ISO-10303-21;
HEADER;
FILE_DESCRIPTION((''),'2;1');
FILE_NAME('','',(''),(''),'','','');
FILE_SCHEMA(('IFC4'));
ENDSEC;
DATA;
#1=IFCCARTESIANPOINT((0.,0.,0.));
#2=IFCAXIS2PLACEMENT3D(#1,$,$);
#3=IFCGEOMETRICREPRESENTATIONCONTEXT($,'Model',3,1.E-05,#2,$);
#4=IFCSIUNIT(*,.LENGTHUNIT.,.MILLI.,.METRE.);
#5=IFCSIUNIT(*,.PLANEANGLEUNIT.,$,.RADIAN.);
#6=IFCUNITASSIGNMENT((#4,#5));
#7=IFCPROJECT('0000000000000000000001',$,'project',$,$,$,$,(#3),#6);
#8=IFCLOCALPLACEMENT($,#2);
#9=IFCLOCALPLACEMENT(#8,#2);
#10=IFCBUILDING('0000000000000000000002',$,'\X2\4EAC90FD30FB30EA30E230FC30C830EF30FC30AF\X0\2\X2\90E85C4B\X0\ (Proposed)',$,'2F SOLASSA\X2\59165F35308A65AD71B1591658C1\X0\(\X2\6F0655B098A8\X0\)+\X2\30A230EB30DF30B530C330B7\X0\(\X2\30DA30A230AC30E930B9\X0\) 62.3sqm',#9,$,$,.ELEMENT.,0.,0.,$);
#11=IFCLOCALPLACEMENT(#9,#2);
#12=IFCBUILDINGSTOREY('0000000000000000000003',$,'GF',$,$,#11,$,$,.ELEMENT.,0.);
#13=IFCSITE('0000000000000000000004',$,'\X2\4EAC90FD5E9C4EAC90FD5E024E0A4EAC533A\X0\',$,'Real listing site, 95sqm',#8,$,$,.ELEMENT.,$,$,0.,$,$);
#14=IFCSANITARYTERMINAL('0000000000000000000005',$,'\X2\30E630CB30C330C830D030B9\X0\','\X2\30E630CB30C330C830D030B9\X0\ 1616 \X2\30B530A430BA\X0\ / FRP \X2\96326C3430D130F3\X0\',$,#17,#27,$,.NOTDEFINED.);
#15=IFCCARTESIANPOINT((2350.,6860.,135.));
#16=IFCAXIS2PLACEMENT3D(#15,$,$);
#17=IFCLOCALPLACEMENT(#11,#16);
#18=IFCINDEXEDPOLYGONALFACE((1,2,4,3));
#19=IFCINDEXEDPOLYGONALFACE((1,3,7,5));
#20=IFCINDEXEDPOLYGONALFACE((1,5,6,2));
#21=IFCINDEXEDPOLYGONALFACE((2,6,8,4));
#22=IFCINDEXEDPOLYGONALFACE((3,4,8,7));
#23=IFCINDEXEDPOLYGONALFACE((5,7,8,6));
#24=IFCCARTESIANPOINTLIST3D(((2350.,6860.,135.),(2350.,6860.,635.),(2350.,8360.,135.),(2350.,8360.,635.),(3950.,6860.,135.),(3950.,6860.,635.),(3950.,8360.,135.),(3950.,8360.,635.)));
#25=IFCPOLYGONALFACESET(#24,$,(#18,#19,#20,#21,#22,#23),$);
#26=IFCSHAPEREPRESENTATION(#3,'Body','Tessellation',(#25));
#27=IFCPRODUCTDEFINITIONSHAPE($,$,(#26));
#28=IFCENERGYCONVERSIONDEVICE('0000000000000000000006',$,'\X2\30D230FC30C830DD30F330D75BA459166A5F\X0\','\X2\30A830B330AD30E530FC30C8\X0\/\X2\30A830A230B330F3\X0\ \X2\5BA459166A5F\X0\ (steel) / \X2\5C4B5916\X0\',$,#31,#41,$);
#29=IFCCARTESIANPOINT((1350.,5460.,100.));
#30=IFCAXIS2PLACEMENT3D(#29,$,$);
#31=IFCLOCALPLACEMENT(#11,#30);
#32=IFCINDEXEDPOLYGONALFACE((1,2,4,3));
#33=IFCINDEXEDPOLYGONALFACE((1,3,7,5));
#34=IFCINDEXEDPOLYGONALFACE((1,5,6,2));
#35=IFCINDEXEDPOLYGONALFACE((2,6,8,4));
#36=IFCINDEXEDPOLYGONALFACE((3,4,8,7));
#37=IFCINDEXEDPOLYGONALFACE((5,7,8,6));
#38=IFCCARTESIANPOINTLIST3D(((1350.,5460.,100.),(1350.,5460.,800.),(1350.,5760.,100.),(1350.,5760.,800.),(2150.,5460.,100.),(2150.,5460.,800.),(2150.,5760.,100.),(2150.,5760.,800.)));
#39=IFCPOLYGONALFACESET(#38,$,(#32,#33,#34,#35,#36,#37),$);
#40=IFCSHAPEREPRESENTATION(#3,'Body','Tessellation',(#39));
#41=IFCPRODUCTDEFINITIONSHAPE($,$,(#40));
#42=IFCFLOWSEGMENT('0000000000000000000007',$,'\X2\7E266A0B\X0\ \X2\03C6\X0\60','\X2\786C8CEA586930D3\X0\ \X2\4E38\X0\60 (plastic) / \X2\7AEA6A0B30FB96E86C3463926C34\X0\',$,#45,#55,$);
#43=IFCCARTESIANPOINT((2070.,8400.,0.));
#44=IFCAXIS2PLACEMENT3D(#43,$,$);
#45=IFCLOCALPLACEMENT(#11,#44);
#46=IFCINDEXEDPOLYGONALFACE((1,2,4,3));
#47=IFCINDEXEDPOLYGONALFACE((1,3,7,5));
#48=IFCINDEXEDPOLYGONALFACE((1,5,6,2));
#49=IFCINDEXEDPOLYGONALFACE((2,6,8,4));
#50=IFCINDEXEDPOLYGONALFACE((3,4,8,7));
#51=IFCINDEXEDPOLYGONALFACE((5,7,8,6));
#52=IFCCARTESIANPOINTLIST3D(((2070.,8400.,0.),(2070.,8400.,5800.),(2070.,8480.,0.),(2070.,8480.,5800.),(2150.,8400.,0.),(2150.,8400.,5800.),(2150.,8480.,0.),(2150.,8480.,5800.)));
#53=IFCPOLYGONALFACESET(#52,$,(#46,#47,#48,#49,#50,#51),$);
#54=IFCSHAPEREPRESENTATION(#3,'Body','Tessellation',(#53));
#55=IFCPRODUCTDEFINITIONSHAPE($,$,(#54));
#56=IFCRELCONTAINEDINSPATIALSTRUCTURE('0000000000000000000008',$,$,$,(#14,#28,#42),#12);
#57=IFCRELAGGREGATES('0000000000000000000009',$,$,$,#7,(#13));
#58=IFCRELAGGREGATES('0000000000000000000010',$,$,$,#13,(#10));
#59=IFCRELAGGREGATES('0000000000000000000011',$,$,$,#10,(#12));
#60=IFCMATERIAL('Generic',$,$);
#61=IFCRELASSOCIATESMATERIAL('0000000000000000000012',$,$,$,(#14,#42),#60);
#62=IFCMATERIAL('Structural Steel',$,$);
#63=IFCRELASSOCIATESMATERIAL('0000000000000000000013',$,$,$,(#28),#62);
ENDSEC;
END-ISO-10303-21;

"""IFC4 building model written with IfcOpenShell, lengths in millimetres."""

from ifc_helpers import new_model, si_unit, frame, frame_2d, origin, place, context, project, spatial, rectangle, extrude, material, element, save


model = new_model("IFC4")

# Units and contexts
model_context = context("Model", 3, precision=1e-05, world=origin())
ifc_project = project(units=[si_unit("LENGTHUNIT", "METRE", prefix="MILLI"), si_unit("PLANEANGLEUNIT", "RADIAN")], contexts=[model_context])

# Site, building, storey
site_placement = place(None, origin())
site = spatial("IfcSite", under=ifc_project, at=site_placement, Name="京都府京都市上京区", ObjectType="Real listing site, 95sqm", CompositionType="ELEMENT", RefElevation=0.0)
building_placement = place(site_placement, origin())
building = spatial("IfcBuilding", under=site, at=building_placement, Name="京都・リモートワーク2部屋 (Proposed)", ObjectType="2F SOLASSA外張り断熱外壁(漆喰風)+アルミサッシ(ペアガラス) 62.3sqm", CompositionType="ELEMENT", ElevationOfRefHeight=0.0, ElevationOfTerrain=0.0)
storey_placement = place(building_placement, origin())
storey = spatial("IfcBuildingStorey", under=building, at=storey_placement, Name="GF", CompositionType="ELEMENT", Elevation=0.0)

# Shared definitions
ifc_material_1 = material(Name="Generic")

# Sanitary terminal
sanitary_terminal_placement = place(storey_placement, frame((2350.0, 6860.0, 135.0)))
element("IfcSanitaryTerminal", 1, at=sanitary_terminal_placement, inside=storey, material=ifc_material_1, Name="ユニットバス", Description="ユニットバス 1616 サイズ / FRP 防水パン", PredefinedType="NOTDEFINED", context=model_context, shape_type="SweptSolid", body=[
    extrude(rectangle(XDim=1600.0, YDim=1500.0, at=frame_2d((800.0, 750.0))), frame((2350.0, 6860.0, 135.0)), (0.0, 0.0, 1.0), 500.0),
])

# Energy conversion device
ifc_material_2 = material(Name="Structural Steel")
energy_conversion_device_placement = place(storey_placement, frame((1350.0, 5460.0, 100.0)))
element("IfcEnergyConversionDevice", 2, at=energy_conversion_device_placement, inside=storey, material=ifc_material_2, Name="ヒートポンプ室外機", Description="エコキュート/エアコン 室外機 (steel) / 屋外", context=model_context, shape_type="SweptSolid", body=[
    extrude(rectangle(XDim=800.0, YDim=300.0, at=frame_2d((400.0, 150.0))), frame((1350.0, 5460.0, 100.0)), (0.0, 0.0, 1.0), 700.0),
])

# Flow segment
flow_segment_placement = place(storey_placement, frame((2070.0, 8400.0, 0.0)))
element("IfcFlowSegment", 3, at=flow_segment_placement, inside=storey, material=ifc_material_1, Name="縦樋 φ60", Description="硬質塩ビ 丸60 (plastic) / 竪樋・雨水排水", context=model_context, shape_type="SweptSolid", body=[
    extrude(rectangle(XDim=80.0, YDim=80.0, at=frame_2d((40.0, 40.0))), frame((2070.0, 8400.0, 0.0)), (0.0, 0.0, 1.0), 5800.0),
])

save(model, "model.ifc")
